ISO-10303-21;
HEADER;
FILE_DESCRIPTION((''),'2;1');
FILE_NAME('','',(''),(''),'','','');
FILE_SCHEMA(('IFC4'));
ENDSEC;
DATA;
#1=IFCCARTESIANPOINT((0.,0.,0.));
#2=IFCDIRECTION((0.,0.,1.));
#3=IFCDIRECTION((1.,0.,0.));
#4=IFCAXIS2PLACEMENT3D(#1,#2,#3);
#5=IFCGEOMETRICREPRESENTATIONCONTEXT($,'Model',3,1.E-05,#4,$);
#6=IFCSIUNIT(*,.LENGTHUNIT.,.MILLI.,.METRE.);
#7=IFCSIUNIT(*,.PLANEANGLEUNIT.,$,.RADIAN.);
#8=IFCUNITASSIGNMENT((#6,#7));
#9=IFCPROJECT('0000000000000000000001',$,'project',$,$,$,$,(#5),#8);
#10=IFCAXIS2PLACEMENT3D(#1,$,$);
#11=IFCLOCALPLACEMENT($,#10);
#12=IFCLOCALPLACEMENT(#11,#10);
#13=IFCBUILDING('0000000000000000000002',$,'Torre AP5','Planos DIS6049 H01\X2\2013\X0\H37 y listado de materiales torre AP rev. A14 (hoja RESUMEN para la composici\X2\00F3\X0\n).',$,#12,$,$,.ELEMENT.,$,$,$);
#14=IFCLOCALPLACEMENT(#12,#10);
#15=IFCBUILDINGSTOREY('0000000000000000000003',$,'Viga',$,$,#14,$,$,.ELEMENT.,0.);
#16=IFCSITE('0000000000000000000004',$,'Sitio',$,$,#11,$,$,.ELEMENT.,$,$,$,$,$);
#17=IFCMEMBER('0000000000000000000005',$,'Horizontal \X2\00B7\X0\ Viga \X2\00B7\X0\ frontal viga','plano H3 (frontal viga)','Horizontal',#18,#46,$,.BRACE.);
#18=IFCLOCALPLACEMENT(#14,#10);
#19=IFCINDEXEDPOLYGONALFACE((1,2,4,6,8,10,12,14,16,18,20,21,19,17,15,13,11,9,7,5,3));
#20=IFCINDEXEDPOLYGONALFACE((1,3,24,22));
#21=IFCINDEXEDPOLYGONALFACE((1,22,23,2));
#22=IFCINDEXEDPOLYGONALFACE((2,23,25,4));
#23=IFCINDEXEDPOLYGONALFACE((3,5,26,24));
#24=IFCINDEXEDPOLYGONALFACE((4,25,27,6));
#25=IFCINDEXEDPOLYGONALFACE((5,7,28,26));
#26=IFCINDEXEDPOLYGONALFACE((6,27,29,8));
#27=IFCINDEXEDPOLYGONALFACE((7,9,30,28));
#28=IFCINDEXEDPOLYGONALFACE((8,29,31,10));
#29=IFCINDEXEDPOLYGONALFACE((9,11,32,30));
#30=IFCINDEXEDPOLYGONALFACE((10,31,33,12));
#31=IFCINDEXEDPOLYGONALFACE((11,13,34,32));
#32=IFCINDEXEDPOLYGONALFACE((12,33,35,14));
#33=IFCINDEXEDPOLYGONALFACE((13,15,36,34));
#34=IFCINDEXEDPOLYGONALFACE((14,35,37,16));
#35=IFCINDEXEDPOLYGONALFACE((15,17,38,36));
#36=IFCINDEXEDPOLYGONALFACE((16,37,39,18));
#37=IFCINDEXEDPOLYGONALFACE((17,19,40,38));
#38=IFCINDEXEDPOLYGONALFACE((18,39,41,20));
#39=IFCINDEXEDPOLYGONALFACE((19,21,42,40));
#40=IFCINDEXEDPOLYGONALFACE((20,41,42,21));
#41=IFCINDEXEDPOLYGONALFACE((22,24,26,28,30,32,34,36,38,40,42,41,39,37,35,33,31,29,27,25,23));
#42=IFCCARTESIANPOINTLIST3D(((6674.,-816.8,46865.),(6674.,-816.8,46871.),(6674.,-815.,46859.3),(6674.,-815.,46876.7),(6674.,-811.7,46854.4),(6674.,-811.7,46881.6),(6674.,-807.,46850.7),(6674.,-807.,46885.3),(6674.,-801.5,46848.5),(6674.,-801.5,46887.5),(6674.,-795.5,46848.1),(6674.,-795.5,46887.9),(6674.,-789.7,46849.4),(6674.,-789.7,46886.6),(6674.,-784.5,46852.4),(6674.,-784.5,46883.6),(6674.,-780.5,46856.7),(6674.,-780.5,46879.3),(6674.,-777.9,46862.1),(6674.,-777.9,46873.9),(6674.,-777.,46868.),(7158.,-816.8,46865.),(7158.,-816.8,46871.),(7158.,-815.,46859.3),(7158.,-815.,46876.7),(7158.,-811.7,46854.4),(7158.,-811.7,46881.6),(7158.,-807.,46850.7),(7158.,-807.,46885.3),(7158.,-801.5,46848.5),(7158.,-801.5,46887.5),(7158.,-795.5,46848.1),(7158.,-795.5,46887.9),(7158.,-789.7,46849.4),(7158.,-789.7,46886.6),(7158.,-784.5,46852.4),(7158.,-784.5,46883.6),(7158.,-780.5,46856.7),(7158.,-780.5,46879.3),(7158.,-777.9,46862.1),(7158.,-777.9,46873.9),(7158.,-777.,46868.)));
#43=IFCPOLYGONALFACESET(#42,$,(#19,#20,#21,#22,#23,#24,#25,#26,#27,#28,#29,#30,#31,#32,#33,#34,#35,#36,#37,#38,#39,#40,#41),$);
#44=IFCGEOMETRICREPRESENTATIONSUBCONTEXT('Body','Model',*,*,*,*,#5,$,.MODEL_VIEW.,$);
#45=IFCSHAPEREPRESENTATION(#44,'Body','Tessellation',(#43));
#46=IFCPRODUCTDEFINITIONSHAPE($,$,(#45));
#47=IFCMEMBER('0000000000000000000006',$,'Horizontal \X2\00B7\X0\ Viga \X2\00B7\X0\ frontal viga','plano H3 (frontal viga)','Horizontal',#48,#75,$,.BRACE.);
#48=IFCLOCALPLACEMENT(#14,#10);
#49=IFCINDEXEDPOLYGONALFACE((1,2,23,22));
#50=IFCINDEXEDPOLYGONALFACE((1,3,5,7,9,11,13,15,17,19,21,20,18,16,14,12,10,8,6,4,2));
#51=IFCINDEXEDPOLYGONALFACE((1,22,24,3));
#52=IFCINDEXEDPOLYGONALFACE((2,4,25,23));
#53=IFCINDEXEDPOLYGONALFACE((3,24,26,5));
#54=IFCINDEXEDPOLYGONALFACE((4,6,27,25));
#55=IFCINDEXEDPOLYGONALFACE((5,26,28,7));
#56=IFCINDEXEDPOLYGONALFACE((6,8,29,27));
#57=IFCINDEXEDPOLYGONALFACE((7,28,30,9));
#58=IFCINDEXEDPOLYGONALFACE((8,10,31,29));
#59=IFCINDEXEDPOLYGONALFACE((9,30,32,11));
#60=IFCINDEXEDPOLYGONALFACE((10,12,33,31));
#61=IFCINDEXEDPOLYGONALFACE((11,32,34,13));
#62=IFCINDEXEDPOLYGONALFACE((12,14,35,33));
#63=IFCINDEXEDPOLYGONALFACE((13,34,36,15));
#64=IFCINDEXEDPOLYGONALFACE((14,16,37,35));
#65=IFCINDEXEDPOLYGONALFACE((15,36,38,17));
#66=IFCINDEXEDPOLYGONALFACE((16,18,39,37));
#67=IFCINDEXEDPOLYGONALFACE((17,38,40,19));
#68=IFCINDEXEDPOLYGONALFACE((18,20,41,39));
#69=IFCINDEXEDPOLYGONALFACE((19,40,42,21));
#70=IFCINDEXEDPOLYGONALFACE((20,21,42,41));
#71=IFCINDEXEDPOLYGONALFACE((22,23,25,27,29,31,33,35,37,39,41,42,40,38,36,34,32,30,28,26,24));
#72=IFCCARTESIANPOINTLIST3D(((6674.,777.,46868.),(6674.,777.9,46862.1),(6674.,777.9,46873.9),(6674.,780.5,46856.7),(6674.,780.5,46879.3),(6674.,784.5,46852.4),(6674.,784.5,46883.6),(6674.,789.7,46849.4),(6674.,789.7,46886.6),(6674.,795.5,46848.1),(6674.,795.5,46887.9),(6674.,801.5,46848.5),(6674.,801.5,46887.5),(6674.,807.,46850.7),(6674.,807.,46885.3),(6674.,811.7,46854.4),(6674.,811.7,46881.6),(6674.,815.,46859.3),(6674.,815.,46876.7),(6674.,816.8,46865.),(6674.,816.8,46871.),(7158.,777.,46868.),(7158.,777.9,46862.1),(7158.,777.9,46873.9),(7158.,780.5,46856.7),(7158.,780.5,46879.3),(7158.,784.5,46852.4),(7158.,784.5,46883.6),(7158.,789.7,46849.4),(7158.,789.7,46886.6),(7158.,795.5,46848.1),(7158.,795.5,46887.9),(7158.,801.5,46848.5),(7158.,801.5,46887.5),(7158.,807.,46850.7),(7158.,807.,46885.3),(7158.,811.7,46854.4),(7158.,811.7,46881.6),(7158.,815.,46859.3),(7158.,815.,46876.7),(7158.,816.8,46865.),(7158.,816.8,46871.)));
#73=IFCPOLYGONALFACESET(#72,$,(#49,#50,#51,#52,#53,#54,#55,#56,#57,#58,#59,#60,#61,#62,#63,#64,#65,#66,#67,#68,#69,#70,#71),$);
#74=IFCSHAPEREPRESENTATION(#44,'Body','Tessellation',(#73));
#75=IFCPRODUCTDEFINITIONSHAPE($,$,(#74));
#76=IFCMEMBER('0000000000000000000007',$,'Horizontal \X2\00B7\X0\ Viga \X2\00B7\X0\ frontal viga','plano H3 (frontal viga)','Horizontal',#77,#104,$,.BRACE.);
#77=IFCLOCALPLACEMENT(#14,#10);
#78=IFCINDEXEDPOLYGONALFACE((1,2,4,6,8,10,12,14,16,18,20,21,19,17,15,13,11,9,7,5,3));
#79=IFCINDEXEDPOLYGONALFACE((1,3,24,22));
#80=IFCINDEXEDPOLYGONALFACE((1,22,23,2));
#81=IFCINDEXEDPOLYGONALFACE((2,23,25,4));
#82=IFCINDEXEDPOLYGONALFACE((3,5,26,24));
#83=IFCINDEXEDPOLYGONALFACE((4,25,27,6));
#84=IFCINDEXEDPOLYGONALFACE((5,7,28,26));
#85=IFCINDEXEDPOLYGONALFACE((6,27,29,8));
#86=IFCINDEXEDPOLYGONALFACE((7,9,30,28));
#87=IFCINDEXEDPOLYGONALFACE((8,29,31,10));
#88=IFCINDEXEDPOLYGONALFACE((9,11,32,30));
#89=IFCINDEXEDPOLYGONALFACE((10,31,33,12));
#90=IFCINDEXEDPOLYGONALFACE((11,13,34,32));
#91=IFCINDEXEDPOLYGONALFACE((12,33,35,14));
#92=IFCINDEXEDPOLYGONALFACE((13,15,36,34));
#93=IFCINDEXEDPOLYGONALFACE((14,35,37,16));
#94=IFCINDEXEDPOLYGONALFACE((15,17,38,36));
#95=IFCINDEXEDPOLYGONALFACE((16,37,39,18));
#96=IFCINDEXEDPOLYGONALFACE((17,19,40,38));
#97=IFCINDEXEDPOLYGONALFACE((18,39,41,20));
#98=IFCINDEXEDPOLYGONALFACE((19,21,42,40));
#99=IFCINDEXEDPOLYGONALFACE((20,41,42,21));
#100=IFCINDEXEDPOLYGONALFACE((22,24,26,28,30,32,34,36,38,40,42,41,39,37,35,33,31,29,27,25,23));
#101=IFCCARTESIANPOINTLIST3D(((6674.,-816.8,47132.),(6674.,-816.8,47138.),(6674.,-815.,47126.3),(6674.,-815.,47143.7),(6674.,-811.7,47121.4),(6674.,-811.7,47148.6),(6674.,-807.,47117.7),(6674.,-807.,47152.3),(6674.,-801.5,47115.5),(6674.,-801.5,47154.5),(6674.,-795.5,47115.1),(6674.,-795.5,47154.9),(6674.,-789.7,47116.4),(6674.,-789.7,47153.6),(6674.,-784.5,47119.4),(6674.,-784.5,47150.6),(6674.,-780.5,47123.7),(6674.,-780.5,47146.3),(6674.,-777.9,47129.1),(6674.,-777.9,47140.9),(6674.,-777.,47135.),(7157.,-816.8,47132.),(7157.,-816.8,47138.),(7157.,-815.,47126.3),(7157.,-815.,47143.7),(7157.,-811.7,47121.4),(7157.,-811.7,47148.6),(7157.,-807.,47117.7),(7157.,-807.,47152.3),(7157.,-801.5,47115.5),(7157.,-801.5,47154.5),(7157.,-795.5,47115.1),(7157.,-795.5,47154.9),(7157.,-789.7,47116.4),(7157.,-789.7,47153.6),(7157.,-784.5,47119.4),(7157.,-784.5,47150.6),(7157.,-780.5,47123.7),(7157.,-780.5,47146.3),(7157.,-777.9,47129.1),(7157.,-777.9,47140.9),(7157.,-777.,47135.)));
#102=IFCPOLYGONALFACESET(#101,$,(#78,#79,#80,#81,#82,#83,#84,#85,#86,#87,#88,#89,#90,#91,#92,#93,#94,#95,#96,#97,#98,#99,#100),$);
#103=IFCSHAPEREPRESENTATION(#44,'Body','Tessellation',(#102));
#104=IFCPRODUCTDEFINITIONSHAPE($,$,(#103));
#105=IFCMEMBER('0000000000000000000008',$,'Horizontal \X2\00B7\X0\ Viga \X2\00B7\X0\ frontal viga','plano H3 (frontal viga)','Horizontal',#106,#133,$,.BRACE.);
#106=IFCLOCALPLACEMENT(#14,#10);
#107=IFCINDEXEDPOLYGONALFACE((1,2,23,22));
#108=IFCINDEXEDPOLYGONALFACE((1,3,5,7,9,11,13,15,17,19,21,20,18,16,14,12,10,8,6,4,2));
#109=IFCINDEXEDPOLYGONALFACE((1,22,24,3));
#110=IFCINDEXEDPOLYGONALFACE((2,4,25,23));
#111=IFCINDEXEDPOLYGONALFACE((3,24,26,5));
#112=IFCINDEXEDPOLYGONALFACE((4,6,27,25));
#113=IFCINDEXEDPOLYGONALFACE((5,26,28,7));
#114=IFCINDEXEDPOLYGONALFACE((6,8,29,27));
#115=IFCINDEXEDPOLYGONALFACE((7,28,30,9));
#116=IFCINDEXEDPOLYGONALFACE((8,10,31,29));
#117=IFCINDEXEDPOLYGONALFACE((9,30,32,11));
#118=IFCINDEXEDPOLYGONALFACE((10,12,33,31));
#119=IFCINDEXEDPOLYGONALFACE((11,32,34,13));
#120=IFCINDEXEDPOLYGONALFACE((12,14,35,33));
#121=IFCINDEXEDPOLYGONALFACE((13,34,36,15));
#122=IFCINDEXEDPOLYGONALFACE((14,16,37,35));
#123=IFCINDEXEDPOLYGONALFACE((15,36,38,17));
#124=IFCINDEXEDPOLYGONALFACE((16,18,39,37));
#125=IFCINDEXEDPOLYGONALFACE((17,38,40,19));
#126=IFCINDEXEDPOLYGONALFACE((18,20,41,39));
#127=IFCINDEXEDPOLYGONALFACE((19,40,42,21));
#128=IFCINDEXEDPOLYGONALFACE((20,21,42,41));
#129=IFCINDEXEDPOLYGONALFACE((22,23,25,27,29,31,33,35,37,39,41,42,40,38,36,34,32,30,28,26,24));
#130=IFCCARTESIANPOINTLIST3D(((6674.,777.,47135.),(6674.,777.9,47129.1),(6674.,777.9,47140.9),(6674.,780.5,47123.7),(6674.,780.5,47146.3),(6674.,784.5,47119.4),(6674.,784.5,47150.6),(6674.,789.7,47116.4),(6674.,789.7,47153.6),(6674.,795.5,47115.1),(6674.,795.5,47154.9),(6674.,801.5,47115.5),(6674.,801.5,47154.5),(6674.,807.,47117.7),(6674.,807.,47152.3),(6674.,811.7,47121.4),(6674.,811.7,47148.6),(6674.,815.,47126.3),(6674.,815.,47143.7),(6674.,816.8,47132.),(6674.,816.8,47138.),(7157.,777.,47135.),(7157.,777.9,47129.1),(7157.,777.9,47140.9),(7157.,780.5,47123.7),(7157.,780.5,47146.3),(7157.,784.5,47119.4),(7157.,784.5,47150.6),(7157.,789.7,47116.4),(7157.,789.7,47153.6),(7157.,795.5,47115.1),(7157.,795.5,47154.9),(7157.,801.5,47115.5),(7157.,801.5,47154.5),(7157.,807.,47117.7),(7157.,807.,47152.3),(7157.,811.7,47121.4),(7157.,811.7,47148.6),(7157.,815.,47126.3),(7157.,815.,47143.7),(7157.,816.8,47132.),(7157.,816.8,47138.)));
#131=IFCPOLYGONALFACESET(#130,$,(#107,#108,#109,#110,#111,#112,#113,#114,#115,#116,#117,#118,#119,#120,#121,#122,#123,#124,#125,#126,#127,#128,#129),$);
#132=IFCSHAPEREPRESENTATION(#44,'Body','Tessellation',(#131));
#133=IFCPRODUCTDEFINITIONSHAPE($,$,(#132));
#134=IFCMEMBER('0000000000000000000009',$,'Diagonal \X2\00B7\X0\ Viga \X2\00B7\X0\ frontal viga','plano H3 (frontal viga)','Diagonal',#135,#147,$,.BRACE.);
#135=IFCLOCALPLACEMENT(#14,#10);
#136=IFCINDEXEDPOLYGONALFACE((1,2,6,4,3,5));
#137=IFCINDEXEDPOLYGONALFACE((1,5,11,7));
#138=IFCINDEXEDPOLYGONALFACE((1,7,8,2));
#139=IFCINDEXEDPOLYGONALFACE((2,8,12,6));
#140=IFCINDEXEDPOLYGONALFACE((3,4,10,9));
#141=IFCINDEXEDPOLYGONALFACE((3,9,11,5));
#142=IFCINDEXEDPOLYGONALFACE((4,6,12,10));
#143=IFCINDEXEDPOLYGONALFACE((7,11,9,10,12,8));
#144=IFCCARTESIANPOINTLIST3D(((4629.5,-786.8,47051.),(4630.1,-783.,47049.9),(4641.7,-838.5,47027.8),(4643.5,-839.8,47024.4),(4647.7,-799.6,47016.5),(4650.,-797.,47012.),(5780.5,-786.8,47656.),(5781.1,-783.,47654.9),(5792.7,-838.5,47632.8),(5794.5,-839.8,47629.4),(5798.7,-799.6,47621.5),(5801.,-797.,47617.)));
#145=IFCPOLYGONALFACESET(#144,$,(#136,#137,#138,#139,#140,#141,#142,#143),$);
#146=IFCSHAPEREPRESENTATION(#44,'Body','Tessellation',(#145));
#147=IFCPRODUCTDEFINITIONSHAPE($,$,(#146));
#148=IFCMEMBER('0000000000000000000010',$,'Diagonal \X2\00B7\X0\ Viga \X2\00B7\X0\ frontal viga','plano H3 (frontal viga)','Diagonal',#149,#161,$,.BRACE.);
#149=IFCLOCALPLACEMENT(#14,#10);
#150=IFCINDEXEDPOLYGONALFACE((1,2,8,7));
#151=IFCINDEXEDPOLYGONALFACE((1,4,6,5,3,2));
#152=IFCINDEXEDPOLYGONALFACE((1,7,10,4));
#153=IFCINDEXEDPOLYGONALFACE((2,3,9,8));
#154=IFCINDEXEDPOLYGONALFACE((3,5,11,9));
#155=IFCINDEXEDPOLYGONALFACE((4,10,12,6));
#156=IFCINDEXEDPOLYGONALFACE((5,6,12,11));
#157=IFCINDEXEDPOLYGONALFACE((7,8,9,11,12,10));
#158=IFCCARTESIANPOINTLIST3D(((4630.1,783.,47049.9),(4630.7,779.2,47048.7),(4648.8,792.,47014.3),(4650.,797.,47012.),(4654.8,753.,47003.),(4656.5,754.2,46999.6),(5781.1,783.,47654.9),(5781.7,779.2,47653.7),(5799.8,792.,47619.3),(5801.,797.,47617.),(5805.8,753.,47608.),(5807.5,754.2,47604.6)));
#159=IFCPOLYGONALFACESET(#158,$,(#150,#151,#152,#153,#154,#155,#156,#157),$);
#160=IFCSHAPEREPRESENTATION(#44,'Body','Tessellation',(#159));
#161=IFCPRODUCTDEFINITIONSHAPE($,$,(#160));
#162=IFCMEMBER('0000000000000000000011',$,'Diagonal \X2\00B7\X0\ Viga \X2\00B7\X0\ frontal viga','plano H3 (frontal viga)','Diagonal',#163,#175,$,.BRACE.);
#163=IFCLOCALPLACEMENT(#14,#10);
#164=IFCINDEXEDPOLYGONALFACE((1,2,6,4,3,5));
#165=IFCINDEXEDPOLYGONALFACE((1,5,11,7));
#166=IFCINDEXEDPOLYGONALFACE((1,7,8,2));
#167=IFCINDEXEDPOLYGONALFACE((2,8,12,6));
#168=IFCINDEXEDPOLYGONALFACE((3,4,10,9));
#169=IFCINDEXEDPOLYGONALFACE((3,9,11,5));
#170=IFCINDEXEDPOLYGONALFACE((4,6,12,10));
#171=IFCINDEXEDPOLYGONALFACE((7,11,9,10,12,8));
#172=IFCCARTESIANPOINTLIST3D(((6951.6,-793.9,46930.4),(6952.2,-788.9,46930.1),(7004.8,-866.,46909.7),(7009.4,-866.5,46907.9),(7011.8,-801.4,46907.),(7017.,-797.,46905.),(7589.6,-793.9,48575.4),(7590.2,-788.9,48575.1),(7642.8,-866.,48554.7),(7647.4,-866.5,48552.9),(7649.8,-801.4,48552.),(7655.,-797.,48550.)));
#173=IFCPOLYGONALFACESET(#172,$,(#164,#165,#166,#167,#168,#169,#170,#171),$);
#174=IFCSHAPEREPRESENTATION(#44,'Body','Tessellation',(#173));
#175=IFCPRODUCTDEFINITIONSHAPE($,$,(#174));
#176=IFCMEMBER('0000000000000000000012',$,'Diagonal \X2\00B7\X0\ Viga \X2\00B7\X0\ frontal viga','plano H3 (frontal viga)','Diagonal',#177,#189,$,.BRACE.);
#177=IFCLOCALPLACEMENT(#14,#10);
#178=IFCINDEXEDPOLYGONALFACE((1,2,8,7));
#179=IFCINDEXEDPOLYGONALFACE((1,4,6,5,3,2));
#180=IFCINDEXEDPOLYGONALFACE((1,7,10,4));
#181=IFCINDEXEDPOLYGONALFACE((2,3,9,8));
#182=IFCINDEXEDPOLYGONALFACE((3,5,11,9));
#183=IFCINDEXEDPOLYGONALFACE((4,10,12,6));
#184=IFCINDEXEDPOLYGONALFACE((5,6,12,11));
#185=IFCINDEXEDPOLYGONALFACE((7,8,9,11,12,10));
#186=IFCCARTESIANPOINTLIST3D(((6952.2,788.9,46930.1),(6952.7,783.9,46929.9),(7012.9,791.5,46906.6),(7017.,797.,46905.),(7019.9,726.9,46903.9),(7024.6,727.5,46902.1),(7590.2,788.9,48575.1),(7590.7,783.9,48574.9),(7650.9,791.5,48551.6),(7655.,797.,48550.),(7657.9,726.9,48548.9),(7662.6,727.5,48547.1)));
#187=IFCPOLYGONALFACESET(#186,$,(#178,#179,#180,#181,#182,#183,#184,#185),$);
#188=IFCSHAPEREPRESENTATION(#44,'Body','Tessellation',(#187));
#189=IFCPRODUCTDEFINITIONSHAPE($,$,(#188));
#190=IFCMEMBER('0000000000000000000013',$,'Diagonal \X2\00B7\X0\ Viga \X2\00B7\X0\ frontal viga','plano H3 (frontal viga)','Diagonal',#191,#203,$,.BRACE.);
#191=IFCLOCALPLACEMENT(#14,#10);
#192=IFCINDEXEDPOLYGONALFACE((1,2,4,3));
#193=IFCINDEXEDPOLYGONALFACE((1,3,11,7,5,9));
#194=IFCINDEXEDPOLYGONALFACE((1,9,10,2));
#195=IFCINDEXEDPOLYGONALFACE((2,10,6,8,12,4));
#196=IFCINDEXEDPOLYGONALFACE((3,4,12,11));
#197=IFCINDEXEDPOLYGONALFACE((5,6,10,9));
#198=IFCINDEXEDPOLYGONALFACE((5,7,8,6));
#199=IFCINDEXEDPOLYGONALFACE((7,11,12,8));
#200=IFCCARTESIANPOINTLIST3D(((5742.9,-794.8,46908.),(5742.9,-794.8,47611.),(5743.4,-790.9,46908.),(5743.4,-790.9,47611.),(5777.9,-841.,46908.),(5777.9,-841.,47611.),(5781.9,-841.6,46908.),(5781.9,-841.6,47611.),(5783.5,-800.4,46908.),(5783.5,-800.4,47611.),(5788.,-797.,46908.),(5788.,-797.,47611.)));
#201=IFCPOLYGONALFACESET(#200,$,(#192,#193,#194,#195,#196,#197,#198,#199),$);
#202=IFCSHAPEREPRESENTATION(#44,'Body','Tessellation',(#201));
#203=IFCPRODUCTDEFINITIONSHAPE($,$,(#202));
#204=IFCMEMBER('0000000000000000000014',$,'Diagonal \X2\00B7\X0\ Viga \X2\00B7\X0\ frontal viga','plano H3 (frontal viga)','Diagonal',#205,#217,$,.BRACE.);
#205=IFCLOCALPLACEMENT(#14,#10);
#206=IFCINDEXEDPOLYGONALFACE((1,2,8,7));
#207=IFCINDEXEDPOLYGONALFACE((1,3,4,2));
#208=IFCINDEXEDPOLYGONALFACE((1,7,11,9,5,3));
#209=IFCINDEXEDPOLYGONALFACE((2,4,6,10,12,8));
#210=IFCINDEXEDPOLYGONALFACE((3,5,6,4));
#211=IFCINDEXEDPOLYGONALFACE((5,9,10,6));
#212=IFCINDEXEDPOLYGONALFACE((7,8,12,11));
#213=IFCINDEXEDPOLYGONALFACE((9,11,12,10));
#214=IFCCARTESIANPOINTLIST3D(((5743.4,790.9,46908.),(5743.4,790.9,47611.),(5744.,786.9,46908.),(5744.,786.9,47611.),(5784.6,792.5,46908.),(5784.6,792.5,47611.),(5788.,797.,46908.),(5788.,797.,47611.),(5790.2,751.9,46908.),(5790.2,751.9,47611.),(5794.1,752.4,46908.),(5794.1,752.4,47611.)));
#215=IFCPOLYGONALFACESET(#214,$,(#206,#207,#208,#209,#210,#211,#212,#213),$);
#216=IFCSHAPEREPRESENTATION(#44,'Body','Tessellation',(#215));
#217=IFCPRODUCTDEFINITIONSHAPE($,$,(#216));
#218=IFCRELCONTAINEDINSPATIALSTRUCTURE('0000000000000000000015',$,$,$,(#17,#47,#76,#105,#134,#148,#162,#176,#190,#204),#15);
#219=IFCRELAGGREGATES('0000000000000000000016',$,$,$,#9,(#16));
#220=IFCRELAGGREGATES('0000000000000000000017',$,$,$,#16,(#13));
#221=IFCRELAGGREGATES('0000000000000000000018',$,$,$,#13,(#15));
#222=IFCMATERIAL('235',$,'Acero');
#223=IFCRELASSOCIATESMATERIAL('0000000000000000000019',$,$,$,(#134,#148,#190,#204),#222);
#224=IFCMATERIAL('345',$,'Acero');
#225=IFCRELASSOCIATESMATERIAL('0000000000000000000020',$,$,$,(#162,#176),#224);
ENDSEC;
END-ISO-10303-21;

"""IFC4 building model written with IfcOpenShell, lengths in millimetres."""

from ifc_helpers import new_model, si_unit, frame, frame_2d, origin, origin_with_axes, place, context, subcontext, project, spatial, circle, l_section, extrude, material, element, save


model = new_model("IFC4")

# Units and contexts
model_context = context("Model", 3, precision=1e-05, world=origin_with_axes())
body_context = subcontext(model_context, "Body", "Model", "MODEL_VIEW")
ifc_project = project(units=[si_unit("LENGTHUNIT", "METRE", prefix="MILLI"), si_unit("PLANEANGLEUNIT", "RADIAN")], contexts=[model_context])

# Site, building, storey
site_placement = place(None, origin())
site = spatial("IfcSite", under=ifc_project, at=site_placement, Name="Sitio", CompositionType="ELEMENT")
building_placement = place(site_placement, origin())
building = spatial("IfcBuilding", under=site, at=building_placement, Name="Torre AP5", Description="Planos DIS6049 H01–H37 y listado de materiales torre AP rev. A14 (hoja RESUMEN para la composición).", CompositionType="ELEMENT")
storey_placement = place(building_placement, origin())
storey = spatial("IfcBuildingStorey", under=building, at=storey_placement, Name="Viga", CompositionType="ELEMENT", Elevation=0.0)

# Members
for number, where, z_axis, x_axis, name in (
    (1, (6674.0, -797.0, 46868.0), (1.0, 0.0, 0.0), (0.0, 1.0, 0.0), "Horizontal · Viga · frontal viga"),
    (2, (6674.0, 797.0, 46868.0), (1.0, 0.0, 0.0), (0.0, -1.0, 0.0), "Horizontal · Viga · frontal viga"),
):
    element("IfcMember", number, at=place(storey_placement, frame(where, z_axis=z_axis, x_axis=x_axis)), inside=storey, Name=name, Description="plano H3 (frontal viga)", ObjectType="Horizontal", PredefinedType="BRACE", context=body_context, shape_type="SweptSolid", body=[
        extrude(circle(Radius=20.0), None, (0.0, 0.0, 1.0), 484.0),
    ])
for number, where, z_axis, x_axis, name in (
    (3, (6674.0, -797.0, 47135.0), (1.0, 0.0, 0.0), (0.0, 1.0, 0.0), "Horizontal · Viga · frontal viga"),
    (4, (6674.0, 797.0, 47135.0), (1.0, 0.0, 0.0), (0.0, -1.0, 0.0), "Horizontal · Viga · frontal viga"),
):
    element("IfcMember", number, at=place(storey_placement, frame(where, z_axis=z_axis, x_axis=x_axis)), inside=storey, Name=name, Description="plano H3 (frontal viga)", ObjectType="Horizontal", PredefinedType="BRACE", context=body_context, shape_type="SweptSolid", body=[
        extrude(circle(Radius=20.0), None, (0.0, 0.0, 1.0), 483.0),
    ])
ifc_material_1 = material(Name="235", Category="Acero")
for number, where, z_axis, x_axis, name in (
    (5, (4650.0, -797.0, 47012.0), (0.885168, 0.0, 0.465271), (-0.442122, 0.311502, 0.841127), "Diagonal · Viga · frontal viga"),
    (6, (4650.0, 797.0, 47012.0), (0.885168, 0.0, 0.465271), (-0.442122, -0.311502, 0.841127), "Diagonal · Viga · frontal viga"),
):
    element("IfcMember", number, at=place(storey_placement, frame(where, z_axis=z_axis, x_axis=x_axis)), inside=storey, material=ifc_material_1, Name=name, Description="plano H3 (frontal viga)", ObjectType="Diagonal", PredefinedType="BRACE", context=body_context, shape_type="SweptSolid", body=[
        extrude(l_section(Depth=45.0, Width=45.0, Thickness=4.0, at=frame_2d((22.5, 22.5))), None, (0.0, 0.0, 1.0), 1300.3),
    ])
ifc_material_2 = material(Name="345", Category="Acero")
for number, where, z_axis, x_axis, name in (
    (7, (7017.0, -797.0, 46905.0), (0.361598, 0.0, 0.932334), (-0.926068, 0.115744, 0.359168), "Diagonal · Viga · frontal viga"),
    (8, (7017.0, 797.0, 46905.0), (0.361598, 0.0, 0.932334), (-0.926068, -0.115744, 0.359168), "Diagonal · Viga · frontal viga"),
):
    element("IfcMember", number, at=place(storey_placement, frame(where, z_axis=z_axis, x_axis=x_axis)), inside=storey, material=ifc_material_2, Name=name, Description="plano H3 (frontal viga)", ObjectType="Diagonal", PredefinedType="BRACE", context=body_context, shape_type="SweptSolid", body=[
        extrude(l_section(Depth=70.0, Width=70.0, Thickness=5.0, at=frame_2d((35.0, 35.0))), None, (0.0, 0.0, 1.0), 1764.4),
    ])
for number, where, z_axis, x_axis, name in (
    (9, (5788.0, -797.0, 46908.0), (0.0, 0.0, 1.0), (-0.990652, 0.136412, 0.0), "Diagonal · Viga · frontal viga"),
    (10, (5788.0, 797.0, 46908.0), (0.0, 0.0, 1.0), (-0.990652, -0.136412, 0.0), "Diagonal · Viga · frontal viga"),
):
    element("IfcMember", number, at=place(storey_placement, frame(where, z_axis=z_axis, x_axis=x_axis)), inside=storey, material=ifc_material_1, Name=name, Description="plano H3 (frontal viga)", ObjectType="Diagonal", PredefinedType="BRACE", context=body_context, shape_type="SweptSolid", body=[
        extrude(l_section(Depth=45.0, Width=45.0, Thickness=4.0, at=frame_2d((22.5, 22.5))), None, (0.0, 0.0, 1.0), 703.0),
    ])

save(model, "model.ifc")
